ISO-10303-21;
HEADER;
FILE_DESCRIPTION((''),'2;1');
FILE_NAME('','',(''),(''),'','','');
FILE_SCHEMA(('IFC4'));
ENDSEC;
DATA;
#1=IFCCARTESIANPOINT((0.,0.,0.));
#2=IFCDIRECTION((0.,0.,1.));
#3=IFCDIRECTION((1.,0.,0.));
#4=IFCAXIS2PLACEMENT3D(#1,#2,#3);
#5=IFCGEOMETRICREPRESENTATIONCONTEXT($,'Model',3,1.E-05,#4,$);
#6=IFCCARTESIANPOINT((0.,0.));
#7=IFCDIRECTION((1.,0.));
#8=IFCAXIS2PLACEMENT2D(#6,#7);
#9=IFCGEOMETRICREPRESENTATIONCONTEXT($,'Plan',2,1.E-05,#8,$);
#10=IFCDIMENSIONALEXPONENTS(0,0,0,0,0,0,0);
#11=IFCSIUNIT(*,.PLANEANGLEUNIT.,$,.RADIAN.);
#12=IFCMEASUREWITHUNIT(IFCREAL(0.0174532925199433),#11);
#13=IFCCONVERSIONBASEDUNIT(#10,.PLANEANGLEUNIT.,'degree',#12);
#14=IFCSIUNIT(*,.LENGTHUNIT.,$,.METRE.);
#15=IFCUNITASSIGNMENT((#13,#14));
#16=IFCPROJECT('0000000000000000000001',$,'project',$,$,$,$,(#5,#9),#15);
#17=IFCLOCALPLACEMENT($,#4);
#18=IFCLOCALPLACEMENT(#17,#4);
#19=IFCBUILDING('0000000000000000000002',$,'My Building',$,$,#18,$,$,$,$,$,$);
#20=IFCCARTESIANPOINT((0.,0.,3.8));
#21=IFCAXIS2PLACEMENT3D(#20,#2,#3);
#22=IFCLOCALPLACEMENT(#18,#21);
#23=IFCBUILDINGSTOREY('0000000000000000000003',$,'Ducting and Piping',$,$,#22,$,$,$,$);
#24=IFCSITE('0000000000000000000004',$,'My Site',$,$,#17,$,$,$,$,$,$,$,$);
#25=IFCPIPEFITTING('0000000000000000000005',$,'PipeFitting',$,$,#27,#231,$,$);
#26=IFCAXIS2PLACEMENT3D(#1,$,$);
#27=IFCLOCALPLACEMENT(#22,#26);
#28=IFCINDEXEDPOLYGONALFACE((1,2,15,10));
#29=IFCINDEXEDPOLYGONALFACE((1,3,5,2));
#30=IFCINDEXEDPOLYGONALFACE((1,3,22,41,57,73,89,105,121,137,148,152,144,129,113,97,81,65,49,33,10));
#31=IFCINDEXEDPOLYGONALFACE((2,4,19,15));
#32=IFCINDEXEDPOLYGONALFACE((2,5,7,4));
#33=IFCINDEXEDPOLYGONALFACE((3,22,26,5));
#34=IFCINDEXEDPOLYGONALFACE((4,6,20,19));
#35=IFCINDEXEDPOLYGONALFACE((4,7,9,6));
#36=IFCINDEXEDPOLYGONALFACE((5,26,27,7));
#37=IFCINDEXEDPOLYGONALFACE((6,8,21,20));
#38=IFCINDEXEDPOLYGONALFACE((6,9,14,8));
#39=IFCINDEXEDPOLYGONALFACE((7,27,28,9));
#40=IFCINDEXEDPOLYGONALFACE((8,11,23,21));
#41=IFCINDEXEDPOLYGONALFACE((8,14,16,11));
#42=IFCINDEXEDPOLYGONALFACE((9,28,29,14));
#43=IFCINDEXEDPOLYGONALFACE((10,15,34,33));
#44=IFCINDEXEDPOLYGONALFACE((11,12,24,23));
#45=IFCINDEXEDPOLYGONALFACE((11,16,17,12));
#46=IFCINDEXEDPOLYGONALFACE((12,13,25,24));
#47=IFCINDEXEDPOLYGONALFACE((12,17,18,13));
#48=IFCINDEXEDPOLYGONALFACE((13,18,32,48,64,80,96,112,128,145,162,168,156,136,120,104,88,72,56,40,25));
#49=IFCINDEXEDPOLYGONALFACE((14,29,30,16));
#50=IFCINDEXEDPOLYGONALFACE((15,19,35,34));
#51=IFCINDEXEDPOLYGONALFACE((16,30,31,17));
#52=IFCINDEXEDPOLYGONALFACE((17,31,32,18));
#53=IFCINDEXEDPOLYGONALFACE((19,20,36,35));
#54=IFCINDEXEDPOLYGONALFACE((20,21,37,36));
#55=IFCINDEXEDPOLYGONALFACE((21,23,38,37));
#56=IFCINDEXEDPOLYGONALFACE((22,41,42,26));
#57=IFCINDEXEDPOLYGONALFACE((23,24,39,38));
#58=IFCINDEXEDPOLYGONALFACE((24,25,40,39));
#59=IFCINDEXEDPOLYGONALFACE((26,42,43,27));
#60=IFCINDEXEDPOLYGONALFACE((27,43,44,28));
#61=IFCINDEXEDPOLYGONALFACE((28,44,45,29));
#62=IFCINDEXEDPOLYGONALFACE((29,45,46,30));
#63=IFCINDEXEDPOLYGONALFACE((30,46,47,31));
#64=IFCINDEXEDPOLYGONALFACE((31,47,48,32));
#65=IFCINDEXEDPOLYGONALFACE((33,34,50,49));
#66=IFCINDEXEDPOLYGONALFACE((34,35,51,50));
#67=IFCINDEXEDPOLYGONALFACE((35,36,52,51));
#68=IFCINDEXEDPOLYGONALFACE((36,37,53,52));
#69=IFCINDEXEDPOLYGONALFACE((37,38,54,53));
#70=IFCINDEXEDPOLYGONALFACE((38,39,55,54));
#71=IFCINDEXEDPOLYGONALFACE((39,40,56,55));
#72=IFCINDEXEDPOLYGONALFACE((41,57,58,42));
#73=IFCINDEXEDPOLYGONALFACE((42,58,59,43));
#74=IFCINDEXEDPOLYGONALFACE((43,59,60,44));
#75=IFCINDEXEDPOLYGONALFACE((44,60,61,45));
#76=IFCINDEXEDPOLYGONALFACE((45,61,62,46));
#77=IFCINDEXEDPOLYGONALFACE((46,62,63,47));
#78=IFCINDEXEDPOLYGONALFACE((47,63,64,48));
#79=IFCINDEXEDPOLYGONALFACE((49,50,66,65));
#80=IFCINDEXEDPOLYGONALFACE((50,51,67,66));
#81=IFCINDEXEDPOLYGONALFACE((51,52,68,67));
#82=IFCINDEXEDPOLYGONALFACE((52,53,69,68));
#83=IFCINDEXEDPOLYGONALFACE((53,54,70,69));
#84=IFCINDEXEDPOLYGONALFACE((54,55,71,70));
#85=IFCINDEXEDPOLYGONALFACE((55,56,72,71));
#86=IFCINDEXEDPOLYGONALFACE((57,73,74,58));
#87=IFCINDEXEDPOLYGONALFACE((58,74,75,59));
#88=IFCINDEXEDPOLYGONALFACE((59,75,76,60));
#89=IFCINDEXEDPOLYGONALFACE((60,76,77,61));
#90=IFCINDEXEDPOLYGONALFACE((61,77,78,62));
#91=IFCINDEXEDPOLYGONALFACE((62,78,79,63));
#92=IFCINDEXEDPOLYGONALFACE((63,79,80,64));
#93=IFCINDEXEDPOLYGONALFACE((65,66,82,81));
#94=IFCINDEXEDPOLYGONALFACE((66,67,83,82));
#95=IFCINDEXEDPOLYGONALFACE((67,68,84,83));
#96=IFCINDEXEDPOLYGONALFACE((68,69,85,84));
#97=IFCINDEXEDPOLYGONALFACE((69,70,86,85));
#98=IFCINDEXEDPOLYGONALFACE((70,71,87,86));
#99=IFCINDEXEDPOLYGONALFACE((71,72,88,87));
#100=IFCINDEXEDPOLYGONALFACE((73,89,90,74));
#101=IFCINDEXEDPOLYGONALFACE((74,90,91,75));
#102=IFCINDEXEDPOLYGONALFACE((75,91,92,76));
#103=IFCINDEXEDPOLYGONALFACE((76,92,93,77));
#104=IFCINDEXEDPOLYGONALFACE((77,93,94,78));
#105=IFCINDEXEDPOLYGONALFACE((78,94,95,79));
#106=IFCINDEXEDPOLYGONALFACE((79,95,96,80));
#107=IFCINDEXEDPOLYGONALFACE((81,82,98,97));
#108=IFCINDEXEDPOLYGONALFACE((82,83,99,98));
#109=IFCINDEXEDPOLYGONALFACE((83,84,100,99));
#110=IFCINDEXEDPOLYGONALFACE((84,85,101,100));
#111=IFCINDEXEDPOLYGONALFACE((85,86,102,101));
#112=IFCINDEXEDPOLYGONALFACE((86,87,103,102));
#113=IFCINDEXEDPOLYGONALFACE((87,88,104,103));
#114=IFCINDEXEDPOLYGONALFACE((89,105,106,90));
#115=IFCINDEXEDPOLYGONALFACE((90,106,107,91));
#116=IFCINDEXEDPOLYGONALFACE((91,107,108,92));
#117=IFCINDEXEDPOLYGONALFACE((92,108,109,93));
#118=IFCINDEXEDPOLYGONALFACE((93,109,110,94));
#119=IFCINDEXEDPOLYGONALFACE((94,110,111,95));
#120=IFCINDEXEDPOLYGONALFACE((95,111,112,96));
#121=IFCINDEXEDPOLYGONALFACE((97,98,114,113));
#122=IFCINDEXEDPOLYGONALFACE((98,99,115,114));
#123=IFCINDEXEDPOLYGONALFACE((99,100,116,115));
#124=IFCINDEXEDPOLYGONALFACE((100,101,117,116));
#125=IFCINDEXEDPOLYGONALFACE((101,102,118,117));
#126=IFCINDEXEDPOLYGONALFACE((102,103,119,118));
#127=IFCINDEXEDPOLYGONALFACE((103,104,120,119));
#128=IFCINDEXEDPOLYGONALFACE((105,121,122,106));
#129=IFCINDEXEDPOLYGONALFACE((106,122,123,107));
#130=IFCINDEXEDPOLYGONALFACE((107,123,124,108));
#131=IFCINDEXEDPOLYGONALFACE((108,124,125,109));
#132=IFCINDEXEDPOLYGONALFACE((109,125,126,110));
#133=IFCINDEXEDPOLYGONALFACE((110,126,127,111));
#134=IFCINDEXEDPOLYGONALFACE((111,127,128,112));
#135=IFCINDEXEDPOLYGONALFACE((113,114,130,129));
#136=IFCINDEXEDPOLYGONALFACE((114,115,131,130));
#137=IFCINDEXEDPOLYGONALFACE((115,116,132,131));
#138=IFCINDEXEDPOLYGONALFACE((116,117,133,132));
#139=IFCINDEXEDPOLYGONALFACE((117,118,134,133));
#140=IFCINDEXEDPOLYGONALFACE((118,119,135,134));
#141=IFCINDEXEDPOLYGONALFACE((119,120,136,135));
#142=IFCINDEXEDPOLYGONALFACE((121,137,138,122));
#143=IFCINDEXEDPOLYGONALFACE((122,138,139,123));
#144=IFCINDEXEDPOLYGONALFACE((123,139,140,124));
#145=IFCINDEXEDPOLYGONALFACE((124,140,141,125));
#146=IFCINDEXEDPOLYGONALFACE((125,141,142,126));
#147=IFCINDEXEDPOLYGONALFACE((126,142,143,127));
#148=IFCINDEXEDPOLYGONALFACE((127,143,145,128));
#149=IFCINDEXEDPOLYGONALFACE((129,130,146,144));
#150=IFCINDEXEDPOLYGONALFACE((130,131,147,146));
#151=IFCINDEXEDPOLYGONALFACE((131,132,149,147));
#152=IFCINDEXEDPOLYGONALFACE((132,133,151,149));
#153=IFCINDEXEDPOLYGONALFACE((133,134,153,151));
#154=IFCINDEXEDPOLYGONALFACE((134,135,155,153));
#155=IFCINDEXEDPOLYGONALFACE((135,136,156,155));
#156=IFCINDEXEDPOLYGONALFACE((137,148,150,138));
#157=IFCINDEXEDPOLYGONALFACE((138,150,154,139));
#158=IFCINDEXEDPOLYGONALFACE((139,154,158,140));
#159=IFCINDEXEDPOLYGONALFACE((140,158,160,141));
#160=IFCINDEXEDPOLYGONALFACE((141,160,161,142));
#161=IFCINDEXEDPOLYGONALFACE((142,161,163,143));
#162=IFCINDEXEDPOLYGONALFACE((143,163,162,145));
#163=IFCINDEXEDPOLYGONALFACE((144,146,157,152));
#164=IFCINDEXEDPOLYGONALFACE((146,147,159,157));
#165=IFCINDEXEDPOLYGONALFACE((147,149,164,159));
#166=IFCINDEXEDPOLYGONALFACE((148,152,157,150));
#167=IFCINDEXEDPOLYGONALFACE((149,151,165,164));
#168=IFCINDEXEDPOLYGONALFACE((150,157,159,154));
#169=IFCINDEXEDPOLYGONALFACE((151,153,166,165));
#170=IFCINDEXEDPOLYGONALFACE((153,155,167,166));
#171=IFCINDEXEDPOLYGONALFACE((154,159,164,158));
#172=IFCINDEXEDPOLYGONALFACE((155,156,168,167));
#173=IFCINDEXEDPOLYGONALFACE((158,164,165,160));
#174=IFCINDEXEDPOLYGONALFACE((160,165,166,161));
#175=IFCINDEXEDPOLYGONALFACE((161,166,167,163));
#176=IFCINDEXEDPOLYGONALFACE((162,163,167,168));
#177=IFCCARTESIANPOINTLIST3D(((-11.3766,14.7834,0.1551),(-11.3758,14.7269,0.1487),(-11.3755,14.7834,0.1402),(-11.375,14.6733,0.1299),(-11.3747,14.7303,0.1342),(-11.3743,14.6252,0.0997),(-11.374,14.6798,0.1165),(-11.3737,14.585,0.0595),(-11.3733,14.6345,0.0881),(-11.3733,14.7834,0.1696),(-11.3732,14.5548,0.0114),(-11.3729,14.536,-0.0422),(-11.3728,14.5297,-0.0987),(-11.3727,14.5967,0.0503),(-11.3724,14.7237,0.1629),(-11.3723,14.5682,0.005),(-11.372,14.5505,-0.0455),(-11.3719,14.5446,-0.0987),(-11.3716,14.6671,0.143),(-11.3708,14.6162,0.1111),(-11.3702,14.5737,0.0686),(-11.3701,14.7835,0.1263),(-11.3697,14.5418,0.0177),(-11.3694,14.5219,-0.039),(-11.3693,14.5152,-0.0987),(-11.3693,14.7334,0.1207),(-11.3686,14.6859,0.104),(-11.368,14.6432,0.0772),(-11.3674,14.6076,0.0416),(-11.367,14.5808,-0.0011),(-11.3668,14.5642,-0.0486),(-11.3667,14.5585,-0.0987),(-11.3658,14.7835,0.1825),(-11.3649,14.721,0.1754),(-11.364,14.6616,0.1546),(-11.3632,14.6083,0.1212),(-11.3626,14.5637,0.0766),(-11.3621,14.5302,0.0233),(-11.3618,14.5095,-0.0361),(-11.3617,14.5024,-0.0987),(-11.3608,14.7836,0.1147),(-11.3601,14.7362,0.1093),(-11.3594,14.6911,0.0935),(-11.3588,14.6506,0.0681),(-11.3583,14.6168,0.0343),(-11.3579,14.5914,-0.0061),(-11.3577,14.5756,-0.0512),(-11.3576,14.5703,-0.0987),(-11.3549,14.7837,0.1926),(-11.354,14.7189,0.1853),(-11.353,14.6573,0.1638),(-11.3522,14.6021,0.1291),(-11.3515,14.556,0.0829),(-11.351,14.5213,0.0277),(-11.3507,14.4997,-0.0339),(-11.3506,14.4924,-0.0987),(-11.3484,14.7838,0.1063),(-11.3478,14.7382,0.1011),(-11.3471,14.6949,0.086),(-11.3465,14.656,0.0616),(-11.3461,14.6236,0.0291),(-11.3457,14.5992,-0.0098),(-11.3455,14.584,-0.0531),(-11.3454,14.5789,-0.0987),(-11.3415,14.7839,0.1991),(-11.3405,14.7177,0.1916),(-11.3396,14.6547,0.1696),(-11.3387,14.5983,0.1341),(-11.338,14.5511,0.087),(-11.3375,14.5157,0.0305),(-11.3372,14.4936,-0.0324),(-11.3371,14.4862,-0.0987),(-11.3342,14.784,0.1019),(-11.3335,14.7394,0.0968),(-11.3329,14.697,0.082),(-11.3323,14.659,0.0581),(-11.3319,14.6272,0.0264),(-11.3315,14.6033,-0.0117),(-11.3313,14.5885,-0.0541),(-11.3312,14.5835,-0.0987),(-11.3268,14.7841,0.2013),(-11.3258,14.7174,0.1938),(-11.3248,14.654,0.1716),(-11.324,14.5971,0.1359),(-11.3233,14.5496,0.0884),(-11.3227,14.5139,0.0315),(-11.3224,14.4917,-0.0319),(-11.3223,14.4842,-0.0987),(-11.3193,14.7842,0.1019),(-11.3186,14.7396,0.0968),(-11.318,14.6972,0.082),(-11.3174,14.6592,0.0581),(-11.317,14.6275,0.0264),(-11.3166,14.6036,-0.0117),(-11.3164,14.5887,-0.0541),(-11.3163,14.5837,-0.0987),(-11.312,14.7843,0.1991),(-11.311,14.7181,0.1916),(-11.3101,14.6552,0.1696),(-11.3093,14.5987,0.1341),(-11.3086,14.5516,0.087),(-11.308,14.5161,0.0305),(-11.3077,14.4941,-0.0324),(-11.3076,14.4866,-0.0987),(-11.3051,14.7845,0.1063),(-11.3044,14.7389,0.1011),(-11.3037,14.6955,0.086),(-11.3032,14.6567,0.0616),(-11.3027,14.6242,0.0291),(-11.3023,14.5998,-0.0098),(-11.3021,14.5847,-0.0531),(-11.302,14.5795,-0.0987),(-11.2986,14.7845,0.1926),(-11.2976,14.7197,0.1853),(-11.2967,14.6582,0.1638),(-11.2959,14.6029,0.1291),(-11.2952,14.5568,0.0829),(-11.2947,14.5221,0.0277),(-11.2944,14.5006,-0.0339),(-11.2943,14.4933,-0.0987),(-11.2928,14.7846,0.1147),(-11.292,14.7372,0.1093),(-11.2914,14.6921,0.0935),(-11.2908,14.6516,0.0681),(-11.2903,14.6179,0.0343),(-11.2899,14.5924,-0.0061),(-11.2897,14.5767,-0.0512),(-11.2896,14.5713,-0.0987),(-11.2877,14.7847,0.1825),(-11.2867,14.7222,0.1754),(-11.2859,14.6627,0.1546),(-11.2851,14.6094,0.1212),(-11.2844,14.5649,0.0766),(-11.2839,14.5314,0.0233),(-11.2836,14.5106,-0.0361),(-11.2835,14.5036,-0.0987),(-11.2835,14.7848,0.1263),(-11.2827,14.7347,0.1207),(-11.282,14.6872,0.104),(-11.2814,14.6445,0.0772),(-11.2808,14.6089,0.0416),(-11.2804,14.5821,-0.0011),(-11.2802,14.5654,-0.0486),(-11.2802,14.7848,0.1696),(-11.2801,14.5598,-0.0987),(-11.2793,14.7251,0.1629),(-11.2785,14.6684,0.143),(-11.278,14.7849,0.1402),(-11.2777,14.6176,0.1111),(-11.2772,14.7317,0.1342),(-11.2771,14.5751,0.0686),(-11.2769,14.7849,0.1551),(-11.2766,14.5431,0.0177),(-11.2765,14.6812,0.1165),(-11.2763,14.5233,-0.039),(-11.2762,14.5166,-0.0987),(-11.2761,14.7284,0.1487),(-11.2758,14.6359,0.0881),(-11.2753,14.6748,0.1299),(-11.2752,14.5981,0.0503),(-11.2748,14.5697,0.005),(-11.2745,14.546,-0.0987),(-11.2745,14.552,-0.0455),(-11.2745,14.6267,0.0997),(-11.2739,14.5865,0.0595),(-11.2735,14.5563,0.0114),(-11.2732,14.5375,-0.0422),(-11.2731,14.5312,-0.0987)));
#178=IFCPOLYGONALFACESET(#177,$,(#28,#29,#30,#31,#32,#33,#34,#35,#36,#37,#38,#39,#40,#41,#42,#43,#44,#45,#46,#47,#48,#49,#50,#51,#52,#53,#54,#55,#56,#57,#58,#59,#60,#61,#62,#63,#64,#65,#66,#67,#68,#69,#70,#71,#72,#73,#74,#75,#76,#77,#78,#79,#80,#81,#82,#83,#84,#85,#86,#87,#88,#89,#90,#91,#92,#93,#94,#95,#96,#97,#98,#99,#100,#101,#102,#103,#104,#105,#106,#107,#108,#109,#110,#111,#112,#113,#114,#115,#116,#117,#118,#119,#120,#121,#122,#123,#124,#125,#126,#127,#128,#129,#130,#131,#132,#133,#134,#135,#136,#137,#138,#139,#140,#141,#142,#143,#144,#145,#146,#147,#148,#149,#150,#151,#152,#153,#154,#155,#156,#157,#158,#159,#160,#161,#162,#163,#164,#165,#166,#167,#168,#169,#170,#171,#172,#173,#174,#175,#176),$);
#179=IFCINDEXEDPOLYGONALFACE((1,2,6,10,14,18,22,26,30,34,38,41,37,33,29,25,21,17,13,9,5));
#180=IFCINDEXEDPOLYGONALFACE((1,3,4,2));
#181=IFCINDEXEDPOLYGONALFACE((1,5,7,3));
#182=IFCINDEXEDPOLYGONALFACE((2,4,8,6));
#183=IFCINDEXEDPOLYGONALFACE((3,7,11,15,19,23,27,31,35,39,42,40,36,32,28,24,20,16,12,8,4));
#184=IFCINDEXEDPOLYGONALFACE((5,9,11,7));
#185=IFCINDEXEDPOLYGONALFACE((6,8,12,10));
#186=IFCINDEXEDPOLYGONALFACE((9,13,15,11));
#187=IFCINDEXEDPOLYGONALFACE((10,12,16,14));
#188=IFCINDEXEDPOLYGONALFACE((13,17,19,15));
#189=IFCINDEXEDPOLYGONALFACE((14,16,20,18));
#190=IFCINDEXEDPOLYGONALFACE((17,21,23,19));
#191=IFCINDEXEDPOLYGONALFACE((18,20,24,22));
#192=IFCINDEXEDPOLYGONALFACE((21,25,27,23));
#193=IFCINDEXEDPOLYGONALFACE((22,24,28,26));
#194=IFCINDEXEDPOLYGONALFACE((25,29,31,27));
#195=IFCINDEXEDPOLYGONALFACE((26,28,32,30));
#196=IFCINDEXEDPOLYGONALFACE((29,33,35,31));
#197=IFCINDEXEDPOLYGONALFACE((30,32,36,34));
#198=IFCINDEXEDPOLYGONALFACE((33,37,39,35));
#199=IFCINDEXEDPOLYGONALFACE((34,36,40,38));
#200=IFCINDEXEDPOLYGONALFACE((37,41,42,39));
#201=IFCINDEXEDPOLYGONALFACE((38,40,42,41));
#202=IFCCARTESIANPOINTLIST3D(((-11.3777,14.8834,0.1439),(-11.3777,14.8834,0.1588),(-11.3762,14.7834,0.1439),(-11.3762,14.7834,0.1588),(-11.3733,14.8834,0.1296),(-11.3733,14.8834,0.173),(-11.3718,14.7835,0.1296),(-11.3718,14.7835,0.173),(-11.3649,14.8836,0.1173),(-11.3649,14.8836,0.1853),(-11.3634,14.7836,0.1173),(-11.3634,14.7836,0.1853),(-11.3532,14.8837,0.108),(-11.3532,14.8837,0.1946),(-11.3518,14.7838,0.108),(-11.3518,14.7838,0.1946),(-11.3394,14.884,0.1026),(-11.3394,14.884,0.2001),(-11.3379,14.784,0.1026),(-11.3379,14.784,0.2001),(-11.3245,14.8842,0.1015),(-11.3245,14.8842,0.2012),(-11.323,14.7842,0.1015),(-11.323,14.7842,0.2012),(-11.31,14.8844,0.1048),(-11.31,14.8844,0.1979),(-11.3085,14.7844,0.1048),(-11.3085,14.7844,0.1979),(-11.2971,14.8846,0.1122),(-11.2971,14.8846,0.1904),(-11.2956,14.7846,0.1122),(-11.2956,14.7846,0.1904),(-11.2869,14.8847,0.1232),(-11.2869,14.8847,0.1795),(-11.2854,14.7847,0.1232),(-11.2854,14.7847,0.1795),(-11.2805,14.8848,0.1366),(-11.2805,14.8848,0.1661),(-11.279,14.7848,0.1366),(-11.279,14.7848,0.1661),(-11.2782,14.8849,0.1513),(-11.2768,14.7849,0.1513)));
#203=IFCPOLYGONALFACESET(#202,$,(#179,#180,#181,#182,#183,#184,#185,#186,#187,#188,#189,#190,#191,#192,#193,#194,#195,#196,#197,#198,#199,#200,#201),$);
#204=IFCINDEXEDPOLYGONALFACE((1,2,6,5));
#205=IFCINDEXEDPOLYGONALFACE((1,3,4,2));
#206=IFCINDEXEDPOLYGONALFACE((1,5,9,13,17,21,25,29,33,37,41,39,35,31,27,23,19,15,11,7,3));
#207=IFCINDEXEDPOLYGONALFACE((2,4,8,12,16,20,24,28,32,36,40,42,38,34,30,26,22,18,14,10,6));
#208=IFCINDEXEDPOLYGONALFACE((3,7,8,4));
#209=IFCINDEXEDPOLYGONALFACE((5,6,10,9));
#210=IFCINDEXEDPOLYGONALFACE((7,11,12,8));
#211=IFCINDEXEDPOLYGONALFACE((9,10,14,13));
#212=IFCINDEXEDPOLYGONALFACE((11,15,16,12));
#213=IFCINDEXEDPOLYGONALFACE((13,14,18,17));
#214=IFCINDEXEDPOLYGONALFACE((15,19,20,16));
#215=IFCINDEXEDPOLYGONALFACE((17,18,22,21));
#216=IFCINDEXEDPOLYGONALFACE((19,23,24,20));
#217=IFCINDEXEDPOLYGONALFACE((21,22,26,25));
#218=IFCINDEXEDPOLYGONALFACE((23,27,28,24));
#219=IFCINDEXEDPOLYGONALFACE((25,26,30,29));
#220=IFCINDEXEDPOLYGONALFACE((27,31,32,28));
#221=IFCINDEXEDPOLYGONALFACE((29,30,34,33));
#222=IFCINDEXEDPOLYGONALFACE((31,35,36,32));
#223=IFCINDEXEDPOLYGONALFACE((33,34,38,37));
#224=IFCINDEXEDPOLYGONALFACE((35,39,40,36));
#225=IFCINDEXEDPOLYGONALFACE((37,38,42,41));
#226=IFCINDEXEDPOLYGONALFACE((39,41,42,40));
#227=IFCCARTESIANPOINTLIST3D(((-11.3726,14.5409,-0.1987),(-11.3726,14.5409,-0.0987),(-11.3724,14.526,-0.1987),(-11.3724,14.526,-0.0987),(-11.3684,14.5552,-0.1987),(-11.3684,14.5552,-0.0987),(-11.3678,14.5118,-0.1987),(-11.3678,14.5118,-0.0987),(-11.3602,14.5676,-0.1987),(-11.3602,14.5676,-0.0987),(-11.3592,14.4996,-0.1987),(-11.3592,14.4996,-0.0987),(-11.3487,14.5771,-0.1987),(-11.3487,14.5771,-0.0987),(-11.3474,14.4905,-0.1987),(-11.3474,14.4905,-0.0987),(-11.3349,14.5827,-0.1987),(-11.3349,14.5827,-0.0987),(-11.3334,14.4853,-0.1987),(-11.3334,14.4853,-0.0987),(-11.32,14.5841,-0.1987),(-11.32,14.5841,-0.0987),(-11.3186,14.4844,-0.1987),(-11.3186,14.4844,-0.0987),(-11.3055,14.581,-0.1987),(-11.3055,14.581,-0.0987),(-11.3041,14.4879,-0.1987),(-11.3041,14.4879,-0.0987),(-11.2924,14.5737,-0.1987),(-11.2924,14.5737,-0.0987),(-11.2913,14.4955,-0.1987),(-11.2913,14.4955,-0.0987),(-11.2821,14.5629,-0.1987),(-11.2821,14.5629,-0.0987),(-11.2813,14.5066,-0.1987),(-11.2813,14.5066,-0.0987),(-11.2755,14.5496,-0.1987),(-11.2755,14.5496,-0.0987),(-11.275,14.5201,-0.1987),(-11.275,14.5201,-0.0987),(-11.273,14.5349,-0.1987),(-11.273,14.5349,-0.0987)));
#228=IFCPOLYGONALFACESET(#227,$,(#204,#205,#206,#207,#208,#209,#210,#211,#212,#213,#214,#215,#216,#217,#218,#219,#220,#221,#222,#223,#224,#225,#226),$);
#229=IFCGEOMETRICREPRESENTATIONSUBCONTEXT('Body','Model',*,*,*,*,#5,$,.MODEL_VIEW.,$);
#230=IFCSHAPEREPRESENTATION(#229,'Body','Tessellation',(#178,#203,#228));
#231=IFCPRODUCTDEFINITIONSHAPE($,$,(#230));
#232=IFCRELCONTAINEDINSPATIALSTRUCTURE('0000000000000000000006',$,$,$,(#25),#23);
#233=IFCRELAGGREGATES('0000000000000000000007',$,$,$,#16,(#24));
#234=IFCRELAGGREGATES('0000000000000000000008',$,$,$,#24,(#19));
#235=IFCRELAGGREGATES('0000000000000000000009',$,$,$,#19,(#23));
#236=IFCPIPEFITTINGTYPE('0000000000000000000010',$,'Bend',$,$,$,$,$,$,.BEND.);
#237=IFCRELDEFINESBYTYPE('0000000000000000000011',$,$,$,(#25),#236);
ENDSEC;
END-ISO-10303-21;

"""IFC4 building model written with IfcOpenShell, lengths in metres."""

from ifc_helpers import new_model, entity, si_unit, converted_unit, frame, origin_with_axes, origin_2d_with_axis, place, context, subcontext, project, spatial, circle, extrude, source, transform, mapped, type_object, type_shapes, element, save


model = new_model("IFC4")

# Units and contexts
model_context = context("Model", 3, precision=1e-05, world=origin_with_axes())
plan_context = context("Plan", 2, precision=1e-05, world=origin_2d_with_axis())
body_context = subcontext(model_context, "Body", "Model", "MODEL_VIEW")
ifc_project = project(units=[converted_unit("PLANEANGLEUNIT", "degree", entity("IfcReal", 0.0174532925199433), si_unit("PLANEANGLEUNIT", "RADIAN"), dimensions=[0, 0, 0, 0, 0, 0, 0]), si_unit("LENGTHUNIT", "METRE")], contexts=[model_context, plan_context])

# Site, building, storey
site_placement = place(None, origin_with_axes())
site = spatial("IfcSite", under=ifc_project, at=site_placement, Name="My Site")
building_placement = place(site_placement, origin_with_axes())
building = spatial("IfcBuilding", under=site, at=building_placement, Name="My Building")
storey_placement = place(building_placement, frame((0.0, 0.0, 3.8), z_axis=(0.0, 0.0, 1.0), x_axis=(1.0, 0.0, 0.0)))
storey = spatial("IfcBuildingStorey", under=building, at=storey_placement, Name="Ducting and Piping")

# Pipe fitting
pipe_fitting_type = type_object("IfcPipeFittingType", Name="Bend", PredefinedType="BEND")
shared_shape = source(origin_with_axes(), body_context, "Body", "SolidModel", [
    entity("IfcSweptDiskSolid", entity("IfcIndexedPolyCurve", entity("IfcCartesianPointList3D", [[0.0, 0.0, 0.1], [0.0, -0.0732, 0.2768], [0.0, -0.25, 0.35]]), [entity("IfcArcIndex", [1, 2, 3])]), 0.05),
    extrude(circle(Radius=0.05), origin_with_axes(), (0.0, 0.0, 1.0), 0.1),
    extrude(circle(Radius=0.05), frame((0.0, -0.25, 0.35), z_axis=(0.0, -1.0, 0.0), x_axis=(1.0, 0.0, 0.0)), (0.0, 0.0, 1.0), 0.1),
])
type_shapes(pipe_fitting_type, [shared_shape])
for number, where, z_axis, x_axis, name in (
    (1, (-11.3282, 14.8841, 0.1513), (0.014879, -0.999889, 0.0), (0.999889, 0.014879, 0.0), "PipeFitting"),
):
    element("IfcPipeFitting", number, at=place(storey_placement, frame(where, z_axis=z_axis, x_axis=x_axis)), inside=storey, type_object=pipe_fitting_type, Name=name, context=body_context, shape_type="MappedRepresentation", body=[
        mapped(shared_shape, transform((0.0, 0.0, 0.0), x_axis=(1.0, 0.0, 0.0), y_axis=(0.0, 1.0, 0.0), z_axis=(0.0, 0.0, 1.0), scale=1.0)),
    ])

save(model, "model.ifc")
